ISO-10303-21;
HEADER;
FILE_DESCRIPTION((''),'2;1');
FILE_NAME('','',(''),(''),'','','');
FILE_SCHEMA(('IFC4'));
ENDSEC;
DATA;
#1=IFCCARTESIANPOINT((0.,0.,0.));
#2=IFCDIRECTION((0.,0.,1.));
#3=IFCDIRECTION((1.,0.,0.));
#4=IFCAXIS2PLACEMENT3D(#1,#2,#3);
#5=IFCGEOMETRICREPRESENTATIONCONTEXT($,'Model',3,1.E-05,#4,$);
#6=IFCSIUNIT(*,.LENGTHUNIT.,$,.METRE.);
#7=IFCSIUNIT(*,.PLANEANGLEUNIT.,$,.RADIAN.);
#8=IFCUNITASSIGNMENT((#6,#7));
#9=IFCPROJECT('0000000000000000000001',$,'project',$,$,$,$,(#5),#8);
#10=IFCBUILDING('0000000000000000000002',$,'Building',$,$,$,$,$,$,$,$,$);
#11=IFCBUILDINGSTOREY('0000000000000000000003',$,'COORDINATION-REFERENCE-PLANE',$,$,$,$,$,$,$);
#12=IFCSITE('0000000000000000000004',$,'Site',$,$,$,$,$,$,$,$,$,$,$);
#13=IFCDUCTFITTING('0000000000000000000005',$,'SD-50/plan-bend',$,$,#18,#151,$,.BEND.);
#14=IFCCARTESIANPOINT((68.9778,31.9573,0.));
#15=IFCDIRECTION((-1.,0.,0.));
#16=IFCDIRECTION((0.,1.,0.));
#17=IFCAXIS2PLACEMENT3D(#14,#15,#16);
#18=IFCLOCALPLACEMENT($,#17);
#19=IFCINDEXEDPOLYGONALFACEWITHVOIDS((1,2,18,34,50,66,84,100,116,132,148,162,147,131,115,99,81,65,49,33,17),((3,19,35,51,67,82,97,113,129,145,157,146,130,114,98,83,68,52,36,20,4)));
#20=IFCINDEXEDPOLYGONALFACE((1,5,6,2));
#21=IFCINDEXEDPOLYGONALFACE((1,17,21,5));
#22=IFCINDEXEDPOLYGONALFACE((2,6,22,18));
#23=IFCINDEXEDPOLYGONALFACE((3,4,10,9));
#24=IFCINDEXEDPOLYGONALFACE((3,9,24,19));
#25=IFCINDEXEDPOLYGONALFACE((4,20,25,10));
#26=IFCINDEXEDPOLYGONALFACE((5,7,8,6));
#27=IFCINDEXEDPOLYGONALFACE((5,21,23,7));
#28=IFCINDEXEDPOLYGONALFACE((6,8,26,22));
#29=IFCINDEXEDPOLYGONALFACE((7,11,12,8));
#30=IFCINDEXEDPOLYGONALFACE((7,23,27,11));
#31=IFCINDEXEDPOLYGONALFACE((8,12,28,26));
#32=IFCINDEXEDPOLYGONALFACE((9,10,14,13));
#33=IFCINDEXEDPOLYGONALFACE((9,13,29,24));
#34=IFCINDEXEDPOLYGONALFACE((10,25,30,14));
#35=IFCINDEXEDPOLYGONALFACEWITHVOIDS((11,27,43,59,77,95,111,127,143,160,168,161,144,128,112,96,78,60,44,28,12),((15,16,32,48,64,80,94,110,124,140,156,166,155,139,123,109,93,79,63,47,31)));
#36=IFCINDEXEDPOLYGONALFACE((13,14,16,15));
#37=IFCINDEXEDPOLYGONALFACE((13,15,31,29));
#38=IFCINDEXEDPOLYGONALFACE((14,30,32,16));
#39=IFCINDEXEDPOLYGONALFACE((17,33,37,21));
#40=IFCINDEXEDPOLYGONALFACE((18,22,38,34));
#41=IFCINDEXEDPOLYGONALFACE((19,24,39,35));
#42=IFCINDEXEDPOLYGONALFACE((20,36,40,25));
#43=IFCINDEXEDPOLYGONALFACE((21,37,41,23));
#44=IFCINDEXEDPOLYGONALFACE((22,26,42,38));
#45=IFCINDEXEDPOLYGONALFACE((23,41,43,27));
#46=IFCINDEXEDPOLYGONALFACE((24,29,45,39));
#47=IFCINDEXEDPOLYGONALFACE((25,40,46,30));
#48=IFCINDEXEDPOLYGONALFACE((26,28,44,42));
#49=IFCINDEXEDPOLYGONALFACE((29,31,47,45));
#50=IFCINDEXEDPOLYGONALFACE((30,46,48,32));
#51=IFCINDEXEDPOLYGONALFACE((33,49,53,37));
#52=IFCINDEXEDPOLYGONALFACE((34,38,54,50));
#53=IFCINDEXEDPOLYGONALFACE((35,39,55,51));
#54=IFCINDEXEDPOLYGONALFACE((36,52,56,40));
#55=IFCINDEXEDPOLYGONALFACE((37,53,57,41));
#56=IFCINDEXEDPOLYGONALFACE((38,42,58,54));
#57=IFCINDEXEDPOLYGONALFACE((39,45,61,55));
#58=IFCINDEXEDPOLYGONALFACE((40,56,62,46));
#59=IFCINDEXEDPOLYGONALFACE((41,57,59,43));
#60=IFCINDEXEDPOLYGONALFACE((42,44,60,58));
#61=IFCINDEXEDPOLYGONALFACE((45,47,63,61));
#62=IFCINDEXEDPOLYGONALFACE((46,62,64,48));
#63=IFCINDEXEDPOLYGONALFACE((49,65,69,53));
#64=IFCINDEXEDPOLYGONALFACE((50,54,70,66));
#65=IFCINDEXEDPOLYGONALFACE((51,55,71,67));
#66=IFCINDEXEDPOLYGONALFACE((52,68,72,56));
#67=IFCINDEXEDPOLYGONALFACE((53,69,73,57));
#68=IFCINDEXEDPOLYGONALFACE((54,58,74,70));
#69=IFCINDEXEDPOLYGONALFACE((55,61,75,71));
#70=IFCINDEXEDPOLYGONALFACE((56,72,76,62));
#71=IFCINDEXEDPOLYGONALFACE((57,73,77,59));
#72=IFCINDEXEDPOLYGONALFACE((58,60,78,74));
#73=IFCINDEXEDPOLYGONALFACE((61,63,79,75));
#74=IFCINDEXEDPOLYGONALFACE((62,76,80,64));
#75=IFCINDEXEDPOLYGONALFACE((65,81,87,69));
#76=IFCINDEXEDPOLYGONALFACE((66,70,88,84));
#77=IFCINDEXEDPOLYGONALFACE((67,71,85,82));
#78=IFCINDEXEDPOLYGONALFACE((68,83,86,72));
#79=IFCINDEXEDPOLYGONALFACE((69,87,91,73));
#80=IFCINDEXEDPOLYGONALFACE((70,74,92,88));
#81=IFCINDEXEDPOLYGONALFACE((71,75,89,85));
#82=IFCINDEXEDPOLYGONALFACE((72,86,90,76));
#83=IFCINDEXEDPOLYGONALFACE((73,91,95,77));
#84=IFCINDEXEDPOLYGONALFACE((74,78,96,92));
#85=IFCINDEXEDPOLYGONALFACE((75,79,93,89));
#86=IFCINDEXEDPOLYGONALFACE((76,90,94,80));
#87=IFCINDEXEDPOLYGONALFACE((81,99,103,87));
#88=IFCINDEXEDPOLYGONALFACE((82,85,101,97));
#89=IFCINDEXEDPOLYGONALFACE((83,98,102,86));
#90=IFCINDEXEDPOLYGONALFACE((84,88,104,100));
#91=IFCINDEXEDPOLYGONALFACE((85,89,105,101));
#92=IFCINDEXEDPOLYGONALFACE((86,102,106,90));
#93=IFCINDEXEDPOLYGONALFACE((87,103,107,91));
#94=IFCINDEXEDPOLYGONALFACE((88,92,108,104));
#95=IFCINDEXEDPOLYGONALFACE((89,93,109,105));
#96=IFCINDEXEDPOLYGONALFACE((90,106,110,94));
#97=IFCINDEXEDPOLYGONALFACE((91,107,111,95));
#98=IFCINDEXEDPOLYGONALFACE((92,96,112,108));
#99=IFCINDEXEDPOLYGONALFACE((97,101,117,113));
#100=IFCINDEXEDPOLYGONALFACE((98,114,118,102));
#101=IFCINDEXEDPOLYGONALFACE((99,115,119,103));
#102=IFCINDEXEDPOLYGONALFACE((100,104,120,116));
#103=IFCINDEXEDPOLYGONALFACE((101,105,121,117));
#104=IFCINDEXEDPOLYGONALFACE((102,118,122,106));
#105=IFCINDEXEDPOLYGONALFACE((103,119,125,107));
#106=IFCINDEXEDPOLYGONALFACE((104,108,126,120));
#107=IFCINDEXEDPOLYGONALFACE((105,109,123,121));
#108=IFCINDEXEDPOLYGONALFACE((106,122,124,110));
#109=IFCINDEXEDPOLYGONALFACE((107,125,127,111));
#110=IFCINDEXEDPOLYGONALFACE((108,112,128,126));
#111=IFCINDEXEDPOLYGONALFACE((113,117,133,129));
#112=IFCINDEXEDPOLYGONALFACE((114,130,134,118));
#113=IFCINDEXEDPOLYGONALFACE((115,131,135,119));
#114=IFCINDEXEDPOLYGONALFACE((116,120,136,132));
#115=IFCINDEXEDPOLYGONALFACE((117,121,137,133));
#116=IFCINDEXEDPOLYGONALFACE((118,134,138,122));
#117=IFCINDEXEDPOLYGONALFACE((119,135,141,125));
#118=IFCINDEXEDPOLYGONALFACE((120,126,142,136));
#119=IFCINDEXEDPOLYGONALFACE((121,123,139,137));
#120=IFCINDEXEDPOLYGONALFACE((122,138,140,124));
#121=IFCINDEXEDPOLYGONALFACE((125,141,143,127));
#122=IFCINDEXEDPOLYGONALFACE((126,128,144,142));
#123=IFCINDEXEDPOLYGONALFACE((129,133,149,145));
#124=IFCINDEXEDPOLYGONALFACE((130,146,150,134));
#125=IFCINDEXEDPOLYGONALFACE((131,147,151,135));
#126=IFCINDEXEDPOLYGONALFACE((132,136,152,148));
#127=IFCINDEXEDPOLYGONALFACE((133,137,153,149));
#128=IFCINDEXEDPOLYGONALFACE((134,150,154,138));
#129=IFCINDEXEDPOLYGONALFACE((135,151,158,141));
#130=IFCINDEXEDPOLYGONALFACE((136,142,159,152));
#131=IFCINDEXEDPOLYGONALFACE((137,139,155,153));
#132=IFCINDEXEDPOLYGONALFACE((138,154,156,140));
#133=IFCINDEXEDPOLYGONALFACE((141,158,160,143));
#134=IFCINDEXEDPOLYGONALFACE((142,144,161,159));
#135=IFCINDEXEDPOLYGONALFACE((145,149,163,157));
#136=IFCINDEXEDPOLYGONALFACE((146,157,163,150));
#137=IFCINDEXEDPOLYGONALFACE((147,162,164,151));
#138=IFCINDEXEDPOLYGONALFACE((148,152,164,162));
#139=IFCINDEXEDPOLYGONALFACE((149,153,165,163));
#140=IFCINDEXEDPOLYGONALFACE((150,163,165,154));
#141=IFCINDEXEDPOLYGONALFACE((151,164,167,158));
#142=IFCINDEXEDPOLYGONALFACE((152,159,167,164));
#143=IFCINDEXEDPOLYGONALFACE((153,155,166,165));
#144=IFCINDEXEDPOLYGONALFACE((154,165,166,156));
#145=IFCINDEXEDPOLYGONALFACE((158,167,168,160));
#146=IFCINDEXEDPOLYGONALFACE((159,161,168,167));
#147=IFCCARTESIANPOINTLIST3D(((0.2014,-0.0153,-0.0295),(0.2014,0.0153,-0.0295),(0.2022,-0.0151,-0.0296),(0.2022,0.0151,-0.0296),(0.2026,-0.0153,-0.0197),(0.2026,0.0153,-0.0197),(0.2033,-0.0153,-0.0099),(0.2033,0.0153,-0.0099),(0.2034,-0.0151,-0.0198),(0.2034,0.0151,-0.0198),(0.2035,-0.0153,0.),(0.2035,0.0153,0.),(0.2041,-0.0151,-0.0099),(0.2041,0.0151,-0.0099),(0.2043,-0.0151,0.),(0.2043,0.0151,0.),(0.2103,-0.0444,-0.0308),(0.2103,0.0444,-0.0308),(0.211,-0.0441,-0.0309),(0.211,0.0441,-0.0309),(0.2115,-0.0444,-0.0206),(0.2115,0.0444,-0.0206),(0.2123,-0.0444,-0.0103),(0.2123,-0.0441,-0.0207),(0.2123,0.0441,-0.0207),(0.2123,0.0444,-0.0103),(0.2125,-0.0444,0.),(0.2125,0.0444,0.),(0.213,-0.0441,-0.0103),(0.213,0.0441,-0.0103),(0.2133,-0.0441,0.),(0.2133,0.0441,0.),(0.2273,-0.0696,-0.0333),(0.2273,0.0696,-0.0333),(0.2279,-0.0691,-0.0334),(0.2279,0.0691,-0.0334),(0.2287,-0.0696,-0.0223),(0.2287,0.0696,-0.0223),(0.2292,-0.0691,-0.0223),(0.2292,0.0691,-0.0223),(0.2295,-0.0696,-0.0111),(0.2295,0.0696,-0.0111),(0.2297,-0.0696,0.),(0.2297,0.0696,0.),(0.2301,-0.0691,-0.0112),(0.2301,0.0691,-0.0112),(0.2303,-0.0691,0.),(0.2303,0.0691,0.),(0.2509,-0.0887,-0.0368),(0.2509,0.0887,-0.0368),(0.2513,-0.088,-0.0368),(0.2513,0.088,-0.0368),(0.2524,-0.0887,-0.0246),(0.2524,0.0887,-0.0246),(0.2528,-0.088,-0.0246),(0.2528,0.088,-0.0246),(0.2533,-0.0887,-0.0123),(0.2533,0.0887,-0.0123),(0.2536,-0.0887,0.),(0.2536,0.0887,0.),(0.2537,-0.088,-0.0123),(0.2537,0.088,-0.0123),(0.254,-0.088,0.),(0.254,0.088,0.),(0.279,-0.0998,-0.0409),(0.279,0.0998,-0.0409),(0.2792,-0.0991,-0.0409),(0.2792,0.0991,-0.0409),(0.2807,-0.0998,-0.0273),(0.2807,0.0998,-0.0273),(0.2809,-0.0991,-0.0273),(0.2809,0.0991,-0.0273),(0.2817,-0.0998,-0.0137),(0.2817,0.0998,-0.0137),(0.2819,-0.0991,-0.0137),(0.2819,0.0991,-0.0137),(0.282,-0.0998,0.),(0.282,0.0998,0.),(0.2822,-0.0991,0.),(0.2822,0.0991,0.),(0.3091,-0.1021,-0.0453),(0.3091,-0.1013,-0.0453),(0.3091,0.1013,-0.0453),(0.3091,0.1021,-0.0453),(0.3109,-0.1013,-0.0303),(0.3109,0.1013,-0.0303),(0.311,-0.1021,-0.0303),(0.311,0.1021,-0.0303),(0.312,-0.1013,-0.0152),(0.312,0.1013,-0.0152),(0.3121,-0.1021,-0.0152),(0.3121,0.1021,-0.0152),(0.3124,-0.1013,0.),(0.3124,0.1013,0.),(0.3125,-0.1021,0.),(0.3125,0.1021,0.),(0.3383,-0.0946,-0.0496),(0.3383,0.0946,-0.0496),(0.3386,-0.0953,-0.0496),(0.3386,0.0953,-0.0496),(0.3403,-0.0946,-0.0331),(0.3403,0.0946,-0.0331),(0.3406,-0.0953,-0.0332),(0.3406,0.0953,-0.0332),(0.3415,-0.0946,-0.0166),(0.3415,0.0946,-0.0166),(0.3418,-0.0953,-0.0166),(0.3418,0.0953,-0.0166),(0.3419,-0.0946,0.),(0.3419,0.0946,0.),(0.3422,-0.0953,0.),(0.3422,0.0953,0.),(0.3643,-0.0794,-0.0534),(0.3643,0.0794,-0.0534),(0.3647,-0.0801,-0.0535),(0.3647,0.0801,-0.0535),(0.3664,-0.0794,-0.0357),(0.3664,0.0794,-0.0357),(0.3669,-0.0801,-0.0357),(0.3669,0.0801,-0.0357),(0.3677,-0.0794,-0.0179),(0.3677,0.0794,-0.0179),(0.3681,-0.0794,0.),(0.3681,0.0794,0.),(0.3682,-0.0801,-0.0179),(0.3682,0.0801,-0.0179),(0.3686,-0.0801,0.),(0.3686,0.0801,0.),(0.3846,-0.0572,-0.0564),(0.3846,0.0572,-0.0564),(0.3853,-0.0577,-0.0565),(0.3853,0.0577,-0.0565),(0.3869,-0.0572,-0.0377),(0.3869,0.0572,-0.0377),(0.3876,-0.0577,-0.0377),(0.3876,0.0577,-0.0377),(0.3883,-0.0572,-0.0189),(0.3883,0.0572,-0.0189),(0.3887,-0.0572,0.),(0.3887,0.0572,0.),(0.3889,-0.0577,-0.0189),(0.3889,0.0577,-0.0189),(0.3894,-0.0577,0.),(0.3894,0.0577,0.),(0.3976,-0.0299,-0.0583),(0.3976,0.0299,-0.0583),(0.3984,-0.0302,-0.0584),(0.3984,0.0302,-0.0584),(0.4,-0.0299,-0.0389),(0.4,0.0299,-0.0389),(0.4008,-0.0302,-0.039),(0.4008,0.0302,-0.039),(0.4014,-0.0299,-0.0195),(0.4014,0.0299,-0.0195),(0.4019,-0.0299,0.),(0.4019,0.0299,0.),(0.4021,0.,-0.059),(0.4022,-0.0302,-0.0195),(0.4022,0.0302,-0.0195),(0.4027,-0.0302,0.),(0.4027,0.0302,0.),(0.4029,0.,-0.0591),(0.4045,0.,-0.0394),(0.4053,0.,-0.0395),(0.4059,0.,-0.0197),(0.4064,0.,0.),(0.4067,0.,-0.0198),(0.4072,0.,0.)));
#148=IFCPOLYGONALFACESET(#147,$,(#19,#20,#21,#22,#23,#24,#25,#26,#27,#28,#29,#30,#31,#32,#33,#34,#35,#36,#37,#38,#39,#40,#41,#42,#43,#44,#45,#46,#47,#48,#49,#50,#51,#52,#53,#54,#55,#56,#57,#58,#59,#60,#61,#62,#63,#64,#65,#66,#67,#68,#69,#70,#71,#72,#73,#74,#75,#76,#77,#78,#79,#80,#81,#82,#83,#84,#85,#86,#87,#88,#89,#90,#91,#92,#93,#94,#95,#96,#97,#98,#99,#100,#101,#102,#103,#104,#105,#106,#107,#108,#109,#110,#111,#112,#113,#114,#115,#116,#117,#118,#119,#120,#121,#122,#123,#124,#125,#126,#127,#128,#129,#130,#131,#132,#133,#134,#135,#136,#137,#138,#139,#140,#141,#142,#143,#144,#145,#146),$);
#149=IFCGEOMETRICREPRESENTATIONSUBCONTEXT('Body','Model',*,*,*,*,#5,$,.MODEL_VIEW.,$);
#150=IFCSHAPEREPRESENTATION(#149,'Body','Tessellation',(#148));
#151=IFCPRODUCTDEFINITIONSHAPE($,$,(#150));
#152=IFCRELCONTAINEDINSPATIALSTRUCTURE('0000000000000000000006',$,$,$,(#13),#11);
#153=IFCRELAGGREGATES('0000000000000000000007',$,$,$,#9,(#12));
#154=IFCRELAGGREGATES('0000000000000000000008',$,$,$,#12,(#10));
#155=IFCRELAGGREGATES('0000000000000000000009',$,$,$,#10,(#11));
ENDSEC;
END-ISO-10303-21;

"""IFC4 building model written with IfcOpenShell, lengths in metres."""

from ifc_helpers import new_model, entity, si_unit, frame, origin_with_axes, place, context, subcontext, project, spatial, element, save


model = new_model("IFC4")

# Units and contexts
model_context = context("Model", 3, precision=1e-05, world=origin_with_axes())
body_context_1 = subcontext(model_context, "Body", "Model", "MODEL_VIEW")
ifc_project = project(units=[si_unit("LENGTHUNIT", "METRE"), si_unit("PLANEANGLEUNIT", "RADIAN")], contexts=[model_context])

# Site, building, storey
site = spatial("IfcSite", under=ifc_project, Name="Site")
building = spatial("IfcBuilding", under=site, Name="Building")
storey = spatial("IfcBuildingStorey", under=building, Name="COORDINATION-REFERENCE-PLANE")

# Duct fitting
duct_fitting_1_placement = place(None, frame((68.9778, 31.9573, 0.0), z_axis=(-1.0, 0.0, 0.0), x_axis=(0.0, 1.0, 0.0)))
element("IfcDuctFitting", 1, at=duct_fitting_1_placement, inside=storey, Name="SD-50/plan-bend", PredefinedType="BEND", context=body_context_1, shape_type="SweptSolid", body=[
    entity("IfcRevolvedAreaSolid", entity("IfcCircleHollowProfileDef", "AREA", None, entity("IfcAxis2Placement2D", entity("IfcCartesianPoint", [0.3048, 0.0])), 0.1024, 0.0008), entity("IfcAxis2Placement3D", entity("IfcCartesianPoint", [0.0, 0.0, 0.0]), entity("IfcDirection", [0.0, 0.0, 1.0]), entity("IfcDirection", [1.0, 0.0, 0.0])), entity("IfcAxis1Placement", entity("IfcCartesianPoint", [0.0, 0.0, 0.0]), entity("IfcDirection", [0.0, 1.0, 0.0])), 0.145576),
])

save(model, "model.ifc")
